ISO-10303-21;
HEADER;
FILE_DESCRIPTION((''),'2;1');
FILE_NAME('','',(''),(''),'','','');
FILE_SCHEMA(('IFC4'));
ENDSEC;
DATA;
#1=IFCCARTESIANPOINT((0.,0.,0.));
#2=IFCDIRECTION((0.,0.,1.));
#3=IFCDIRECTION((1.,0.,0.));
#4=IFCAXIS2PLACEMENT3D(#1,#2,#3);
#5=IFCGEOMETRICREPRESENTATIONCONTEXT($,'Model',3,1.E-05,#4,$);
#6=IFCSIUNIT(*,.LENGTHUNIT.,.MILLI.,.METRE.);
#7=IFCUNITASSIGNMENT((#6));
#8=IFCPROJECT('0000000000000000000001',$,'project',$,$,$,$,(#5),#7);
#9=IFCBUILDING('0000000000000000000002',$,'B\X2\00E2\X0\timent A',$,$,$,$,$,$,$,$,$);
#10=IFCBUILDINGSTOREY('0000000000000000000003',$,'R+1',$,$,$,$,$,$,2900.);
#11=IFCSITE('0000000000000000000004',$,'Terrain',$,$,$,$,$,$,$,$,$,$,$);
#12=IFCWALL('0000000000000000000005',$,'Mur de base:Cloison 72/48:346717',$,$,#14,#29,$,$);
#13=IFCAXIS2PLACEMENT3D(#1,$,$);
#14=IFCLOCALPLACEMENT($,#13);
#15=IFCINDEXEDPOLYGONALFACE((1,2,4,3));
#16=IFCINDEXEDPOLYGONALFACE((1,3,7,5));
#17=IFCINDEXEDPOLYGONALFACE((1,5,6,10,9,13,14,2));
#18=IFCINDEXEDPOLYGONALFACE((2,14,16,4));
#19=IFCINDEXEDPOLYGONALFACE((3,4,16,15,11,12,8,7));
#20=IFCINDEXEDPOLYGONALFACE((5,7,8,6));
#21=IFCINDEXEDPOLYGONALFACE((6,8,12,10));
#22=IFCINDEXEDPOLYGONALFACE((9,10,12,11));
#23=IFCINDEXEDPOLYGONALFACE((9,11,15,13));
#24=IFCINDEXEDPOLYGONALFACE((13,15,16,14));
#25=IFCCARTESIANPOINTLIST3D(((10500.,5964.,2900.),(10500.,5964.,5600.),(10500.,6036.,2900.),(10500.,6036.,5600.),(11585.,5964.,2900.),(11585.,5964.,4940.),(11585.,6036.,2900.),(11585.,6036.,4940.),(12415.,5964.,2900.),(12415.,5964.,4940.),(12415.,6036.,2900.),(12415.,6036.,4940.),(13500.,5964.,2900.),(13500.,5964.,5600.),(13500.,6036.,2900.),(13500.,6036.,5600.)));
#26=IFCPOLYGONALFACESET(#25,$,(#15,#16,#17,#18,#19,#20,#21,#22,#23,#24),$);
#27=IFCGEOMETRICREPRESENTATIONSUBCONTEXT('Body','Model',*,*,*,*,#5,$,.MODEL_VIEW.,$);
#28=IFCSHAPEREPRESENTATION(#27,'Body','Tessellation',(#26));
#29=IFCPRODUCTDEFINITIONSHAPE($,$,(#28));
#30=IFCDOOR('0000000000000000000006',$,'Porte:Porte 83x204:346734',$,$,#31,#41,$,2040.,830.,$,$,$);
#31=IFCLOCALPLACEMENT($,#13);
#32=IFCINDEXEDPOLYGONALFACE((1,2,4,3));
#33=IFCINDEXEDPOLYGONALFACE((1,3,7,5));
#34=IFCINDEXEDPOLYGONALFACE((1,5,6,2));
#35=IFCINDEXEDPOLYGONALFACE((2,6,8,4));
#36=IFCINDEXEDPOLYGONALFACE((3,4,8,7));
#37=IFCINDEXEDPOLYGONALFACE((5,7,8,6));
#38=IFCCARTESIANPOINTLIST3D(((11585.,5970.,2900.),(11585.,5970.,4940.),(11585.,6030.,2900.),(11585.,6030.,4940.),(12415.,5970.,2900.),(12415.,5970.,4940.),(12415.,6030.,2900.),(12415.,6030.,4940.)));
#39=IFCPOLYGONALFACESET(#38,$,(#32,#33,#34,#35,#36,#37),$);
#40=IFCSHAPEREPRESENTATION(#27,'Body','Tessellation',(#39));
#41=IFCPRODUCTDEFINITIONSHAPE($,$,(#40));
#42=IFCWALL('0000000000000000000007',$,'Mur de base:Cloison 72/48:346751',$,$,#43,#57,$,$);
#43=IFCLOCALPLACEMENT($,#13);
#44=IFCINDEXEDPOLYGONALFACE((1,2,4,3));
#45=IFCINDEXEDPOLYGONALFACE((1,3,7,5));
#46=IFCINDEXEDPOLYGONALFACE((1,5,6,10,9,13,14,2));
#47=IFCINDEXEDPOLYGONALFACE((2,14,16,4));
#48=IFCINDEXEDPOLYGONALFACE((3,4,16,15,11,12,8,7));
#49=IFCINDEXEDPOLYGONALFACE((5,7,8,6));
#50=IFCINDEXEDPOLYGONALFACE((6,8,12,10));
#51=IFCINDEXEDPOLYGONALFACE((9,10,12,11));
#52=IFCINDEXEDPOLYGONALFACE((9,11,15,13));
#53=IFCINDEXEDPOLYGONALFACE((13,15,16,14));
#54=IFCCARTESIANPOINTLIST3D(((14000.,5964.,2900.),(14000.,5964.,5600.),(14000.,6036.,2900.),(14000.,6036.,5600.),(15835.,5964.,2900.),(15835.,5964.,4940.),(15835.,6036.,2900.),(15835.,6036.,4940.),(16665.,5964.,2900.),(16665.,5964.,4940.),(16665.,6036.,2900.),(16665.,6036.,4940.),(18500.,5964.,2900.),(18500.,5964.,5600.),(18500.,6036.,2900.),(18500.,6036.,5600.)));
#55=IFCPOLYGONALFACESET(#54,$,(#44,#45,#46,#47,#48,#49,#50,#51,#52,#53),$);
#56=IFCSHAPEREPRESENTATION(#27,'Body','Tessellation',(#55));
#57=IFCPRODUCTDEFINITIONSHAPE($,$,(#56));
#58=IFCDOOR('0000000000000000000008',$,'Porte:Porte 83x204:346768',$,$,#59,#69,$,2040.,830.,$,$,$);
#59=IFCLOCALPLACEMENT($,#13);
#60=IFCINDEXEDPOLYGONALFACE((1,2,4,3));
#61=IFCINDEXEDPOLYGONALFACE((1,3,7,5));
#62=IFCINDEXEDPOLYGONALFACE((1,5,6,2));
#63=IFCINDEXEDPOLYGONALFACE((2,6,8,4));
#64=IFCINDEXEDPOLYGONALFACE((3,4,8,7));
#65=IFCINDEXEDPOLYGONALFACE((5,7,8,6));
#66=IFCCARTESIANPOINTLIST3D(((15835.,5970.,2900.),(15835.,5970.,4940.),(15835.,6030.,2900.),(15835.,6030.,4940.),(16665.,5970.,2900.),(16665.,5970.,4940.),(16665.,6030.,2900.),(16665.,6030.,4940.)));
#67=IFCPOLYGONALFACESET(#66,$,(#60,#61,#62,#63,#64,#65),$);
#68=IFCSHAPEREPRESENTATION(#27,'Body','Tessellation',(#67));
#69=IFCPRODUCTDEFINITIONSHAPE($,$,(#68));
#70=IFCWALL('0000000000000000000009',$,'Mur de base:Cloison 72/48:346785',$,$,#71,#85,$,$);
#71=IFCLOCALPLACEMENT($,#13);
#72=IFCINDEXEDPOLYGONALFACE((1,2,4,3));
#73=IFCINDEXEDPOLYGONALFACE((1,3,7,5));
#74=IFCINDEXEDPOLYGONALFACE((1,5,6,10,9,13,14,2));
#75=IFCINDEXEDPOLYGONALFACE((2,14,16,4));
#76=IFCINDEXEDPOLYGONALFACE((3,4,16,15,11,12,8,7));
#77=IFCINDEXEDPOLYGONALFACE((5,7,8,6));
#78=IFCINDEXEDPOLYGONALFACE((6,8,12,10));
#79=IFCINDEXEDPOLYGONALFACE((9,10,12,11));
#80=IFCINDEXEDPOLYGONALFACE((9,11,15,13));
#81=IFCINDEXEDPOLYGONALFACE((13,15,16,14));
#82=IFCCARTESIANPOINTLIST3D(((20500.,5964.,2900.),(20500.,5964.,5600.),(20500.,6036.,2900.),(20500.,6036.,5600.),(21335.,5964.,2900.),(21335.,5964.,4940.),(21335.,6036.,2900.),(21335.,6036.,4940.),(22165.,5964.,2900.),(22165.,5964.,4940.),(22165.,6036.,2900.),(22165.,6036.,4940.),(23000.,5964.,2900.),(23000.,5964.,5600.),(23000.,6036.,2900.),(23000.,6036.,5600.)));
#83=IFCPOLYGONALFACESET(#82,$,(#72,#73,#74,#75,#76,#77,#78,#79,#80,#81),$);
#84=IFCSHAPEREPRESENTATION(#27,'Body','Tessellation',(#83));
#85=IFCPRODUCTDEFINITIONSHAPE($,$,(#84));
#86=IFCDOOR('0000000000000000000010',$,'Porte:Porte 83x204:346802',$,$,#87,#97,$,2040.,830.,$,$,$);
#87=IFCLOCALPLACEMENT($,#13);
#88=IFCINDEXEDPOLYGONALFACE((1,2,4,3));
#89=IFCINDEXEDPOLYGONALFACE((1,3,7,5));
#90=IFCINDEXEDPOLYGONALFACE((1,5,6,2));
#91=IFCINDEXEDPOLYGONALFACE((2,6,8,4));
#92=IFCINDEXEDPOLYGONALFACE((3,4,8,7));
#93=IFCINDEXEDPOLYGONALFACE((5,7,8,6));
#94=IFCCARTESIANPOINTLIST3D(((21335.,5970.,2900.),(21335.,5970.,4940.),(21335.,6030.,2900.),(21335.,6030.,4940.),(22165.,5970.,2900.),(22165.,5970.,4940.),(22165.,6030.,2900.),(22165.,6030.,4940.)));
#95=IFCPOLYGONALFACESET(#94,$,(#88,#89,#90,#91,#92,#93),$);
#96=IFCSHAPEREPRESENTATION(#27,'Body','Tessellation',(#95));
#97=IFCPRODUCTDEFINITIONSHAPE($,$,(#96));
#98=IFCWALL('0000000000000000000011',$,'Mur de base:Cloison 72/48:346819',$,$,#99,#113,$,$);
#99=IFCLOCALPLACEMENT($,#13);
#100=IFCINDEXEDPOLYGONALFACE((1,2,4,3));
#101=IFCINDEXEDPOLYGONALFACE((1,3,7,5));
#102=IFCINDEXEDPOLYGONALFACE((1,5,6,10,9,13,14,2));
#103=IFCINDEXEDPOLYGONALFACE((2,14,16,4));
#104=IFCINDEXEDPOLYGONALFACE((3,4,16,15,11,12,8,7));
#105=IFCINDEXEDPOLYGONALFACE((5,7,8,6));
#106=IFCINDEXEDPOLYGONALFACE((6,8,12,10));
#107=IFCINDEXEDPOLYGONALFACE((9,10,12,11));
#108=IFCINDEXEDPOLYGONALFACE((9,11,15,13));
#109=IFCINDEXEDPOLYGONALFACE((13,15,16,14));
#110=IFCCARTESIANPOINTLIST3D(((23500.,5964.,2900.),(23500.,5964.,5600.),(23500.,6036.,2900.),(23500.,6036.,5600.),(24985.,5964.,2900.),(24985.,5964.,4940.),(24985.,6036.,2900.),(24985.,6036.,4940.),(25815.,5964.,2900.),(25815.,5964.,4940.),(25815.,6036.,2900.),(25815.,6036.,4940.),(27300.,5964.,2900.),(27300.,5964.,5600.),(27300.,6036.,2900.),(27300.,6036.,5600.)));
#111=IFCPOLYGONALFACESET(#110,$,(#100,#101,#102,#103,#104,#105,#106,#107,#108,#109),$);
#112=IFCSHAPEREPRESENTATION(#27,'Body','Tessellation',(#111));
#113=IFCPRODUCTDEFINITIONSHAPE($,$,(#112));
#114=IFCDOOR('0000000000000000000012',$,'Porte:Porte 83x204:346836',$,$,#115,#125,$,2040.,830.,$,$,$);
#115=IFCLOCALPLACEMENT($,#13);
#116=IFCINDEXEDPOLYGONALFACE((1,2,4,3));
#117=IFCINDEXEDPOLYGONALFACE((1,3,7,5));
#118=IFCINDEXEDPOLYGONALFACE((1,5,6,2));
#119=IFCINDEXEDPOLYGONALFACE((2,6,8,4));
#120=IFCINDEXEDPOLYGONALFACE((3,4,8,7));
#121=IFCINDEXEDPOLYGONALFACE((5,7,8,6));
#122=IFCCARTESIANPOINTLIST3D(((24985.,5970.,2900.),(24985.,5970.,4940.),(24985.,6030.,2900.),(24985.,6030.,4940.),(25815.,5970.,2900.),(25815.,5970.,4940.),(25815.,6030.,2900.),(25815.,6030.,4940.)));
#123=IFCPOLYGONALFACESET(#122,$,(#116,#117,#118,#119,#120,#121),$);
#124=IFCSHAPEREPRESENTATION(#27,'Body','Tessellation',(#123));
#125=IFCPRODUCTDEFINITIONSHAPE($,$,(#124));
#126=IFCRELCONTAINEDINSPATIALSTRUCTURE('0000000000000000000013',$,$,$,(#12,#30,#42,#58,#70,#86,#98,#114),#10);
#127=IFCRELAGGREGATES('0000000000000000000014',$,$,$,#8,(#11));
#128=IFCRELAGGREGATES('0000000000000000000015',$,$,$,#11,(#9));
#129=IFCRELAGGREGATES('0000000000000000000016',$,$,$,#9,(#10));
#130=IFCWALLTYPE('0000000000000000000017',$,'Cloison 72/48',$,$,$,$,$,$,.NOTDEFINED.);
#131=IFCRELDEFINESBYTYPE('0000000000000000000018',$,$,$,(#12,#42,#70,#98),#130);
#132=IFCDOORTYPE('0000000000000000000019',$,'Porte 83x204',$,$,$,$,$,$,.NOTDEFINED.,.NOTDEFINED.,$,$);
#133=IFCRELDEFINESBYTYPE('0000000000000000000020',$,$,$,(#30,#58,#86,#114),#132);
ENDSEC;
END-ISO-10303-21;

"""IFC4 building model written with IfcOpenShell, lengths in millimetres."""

from ifc_helpers import new_model, si_unit, frame, frame_2d, origin_with_axes, place, context, subcontext, project, spatial, rectangle, extrude, type_object, element, fill, save


model = new_model("IFC4")

# Units and contexts
model_context = context("Model", 3, precision=1e-05, world=origin_with_axes())
body_context = subcontext(model_context, "Body", "Model", "MODEL_VIEW")
ifc_project = project(units=[si_unit("LENGTHUNIT", "METRE", prefix="MILLI")], contexts=[model_context])

# Site, building, storey
site = spatial("IfcSite", under=ifc_project, Name="Terrain")
building = spatial("IfcBuilding", under=site, Name="Bâtiment A")
storey = spatial("IfcBuildingStorey", under=building, Name="R+1", Elevation=2900.0)

# Walls, openings, doors
door_type = type_object("IfcDoorType", Name="Porte 83x204", OperationType="NOTDEFINED", PredefinedType="NOTDEFINED")
wall_type_1 = type_object("IfcWallType", Name="Cloison 72/48", PredefinedType="NOTDEFINED")
wall_1_placement = place(None, origin_with_axes())
wall_1 = element("IfcWall", 1, at=wall_1_placement, inside=storey, type_object=wall_type_1, Name="Mur de base:Cloison 72/48:346717", context=body_context, shape_type="SweptSolid", body=[
    extrude(rectangle(XDim=3000.0, YDim=72.0, at=frame_2d((12000.0, 6000.0))), frame((0.0, 0.0, 2900.0), z_axis=(0.0, 0.0, 1.0), x_axis=(1.0, 0.0, 0.0)), (0.0, 0.0, 1.0), 2700.0),
])
opening_1_placement = place(None, origin_with_axes())
opening_1 = element("IfcOpeningElement", 2, at=opening_1_placement, cuts=wall_1, context=body_context, shape_type="SweptSolid", body=[
    extrude(rectangle(XDim=830.0, YDim=192.0, at=frame_2d((12000.0, 6000.0))), frame((0.0, 0.0, 2900.0), z_axis=(0.0, 0.0, 1.0), x_axis=(1.0, 0.0, 0.0)), (0.0, 0.0, 1.0), 2040.0),
])
door_1_placement = place(None, origin_with_axes())
door_1 = element("IfcDoor", 3, at=door_1_placement, inside=storey, type_object=door_type, Name="Porte:Porte 83x204:346734", OverallHeight=2040.0, OverallWidth=830.0, context=body_context, shape_type="SweptSolid", body=[
    extrude(rectangle(XDim=830.0, YDim=60.0, at=frame_2d((12000.0, 6000.0))), frame((0.0, 0.0, 2900.0), z_axis=(0.0, 0.0, 1.0), x_axis=(1.0, 0.0, 0.0)), (0.0, 0.0, 1.0), 2040.0),
])
fill(opening_1, door_1)
wall_2_placement = place(None, origin_with_axes())
wall_2 = element("IfcWall", 4, at=wall_2_placement, inside=storey, type_object=wall_type_1, Name="Mur de base:Cloison 72/48:346751", context=body_context, shape_type="SweptSolid", body=[
    extrude(rectangle(XDim=4500.0, YDim=72.0, at=frame_2d((16250.0, 6000.0))), frame((0.0, 0.0, 2900.0), z_axis=(0.0, 0.0, 1.0), x_axis=(1.0, 0.0, 0.0)), (0.0, 0.0, 1.0), 2700.0),
])
opening_2_placement = place(None, origin_with_axes())
opening_2 = element("IfcOpeningElement", 5, at=opening_2_placement, cuts=wall_2, context=body_context, shape_type="SweptSolid", body=[
    extrude(rectangle(XDim=830.0, YDim=192.0, at=frame_2d((16250.0, 6000.0))), frame((0.0, 0.0, 2900.0), z_axis=(0.0, 0.0, 1.0), x_axis=(1.0, 0.0, 0.0)), (0.0, 0.0, 1.0), 2040.0),
])
door_2_placement = place(None, origin_with_axes())
door_2 = element("IfcDoor", 6, at=door_2_placement, inside=storey, type_object=door_type, Name="Porte:Porte 83x204:346768", OverallHeight=2040.0, OverallWidth=830.0, context=body_context, shape_type="SweptSolid", body=[
    extrude(rectangle(XDim=830.0, YDim=60.0, at=frame_2d((16250.0, 6000.0))), frame((0.0, 0.0, 2900.0), z_axis=(0.0, 0.0, 1.0), x_axis=(1.0, 0.0, 0.0)), (0.0, 0.0, 1.0), 2040.0),
])
fill(opening_2, door_2)
wall_3_placement = place(None, origin_with_axes())
wall_3 = element("IfcWall", 7, at=wall_3_placement, inside=storey, type_object=wall_type_1, Name="Mur de base:Cloison 72/48:346785", context=body_context, shape_type="SweptSolid", body=[
    extrude(rectangle(XDim=2500.0, YDim=72.0, at=frame_2d((21750.0, 6000.0))), frame((0.0, 0.0, 2900.0), z_axis=(0.0, 0.0, 1.0), x_axis=(1.0, 0.0, 0.0)), (0.0, 0.0, 1.0), 2700.0),
])
opening_3_placement = place(None, origin_with_axes())
opening_3 = element("IfcOpeningElement", 8, at=opening_3_placement, cuts=wall_3, context=body_context, shape_type="SweptSolid", body=[
    extrude(rectangle(XDim=830.0, YDim=192.0, at=frame_2d((21750.0, 6000.0))), frame((0.0, 0.0, 2900.0), z_axis=(0.0, 0.0, 1.0), x_axis=(1.0, 0.0, 0.0)), (0.0, 0.0, 1.0), 2040.0),
])
door_3_placement = place(None, origin_with_axes())
door_3 = element("IfcDoor", 9, at=door_3_placement, inside=storey, type_object=door_type, Name="Porte:Porte 83x204:346802", OverallHeight=2040.0, OverallWidth=830.0, context=body_context, shape_type="SweptSolid", body=[
    extrude(rectangle(XDim=830.0, YDim=60.0, at=frame_2d((21750.0, 6000.0))), frame((0.0, 0.0, 2900.0), z_axis=(0.0, 0.0, 1.0), x_axis=(1.0, 0.0, 0.0)), (0.0, 0.0, 1.0), 2040.0),
])
fill(opening_3, door_3)
wall_4_placement = place(None, origin_with_axes())
wall_4 = element("IfcWall", 10, at=wall_4_placement, inside=storey, type_object=wall_type_1, Name="Mur de base:Cloison 72/48:346819", context=body_context, shape_type="SweptSolid", body=[
    extrude(rectangle(XDim=3800.0, YDim=72.0, at=frame_2d((25400.0, 6000.0))), frame((0.0, 0.0, 2900.0), z_axis=(0.0, 0.0, 1.0), x_axis=(1.0, 0.0, 0.0)), (0.0, 0.0, 1.0), 2700.0),
])
opening_4_placement = place(None, origin_with_axes())
opening_4 = element("IfcOpeningElement", 11, at=opening_4_placement, cuts=wall_4, context=body_context, shape_type="SweptSolid", body=[
    extrude(rectangle(XDim=830.0, YDim=192.0, at=frame_2d((25400.0, 6000.0))), frame((0.0, 0.0, 2900.0), z_axis=(0.0, 0.0, 1.0), x_axis=(1.0, 0.0, 0.0)), (0.0, 0.0, 1.0), 2040.0),
])
door_4_placement = place(None, origin_with_axes())
door_4 = element("IfcDoor", 12, at=door_4_placement, inside=storey, type_object=door_type, Name="Porte:Porte 83x204:346836", OverallHeight=2040.0, OverallWidth=830.0, context=body_context, shape_type="SweptSolid", body=[
    extrude(rectangle(XDim=830.0, YDim=60.0, at=frame_2d((25400.0, 6000.0))), frame((0.0, 0.0, 2900.0), z_axis=(0.0, 0.0, 1.0), x_axis=(1.0, 0.0, 0.0)), (0.0, 0.0, 1.0), 2040.0),
])
fill(opening_4, door_4)

save(model, "model.ifc")
